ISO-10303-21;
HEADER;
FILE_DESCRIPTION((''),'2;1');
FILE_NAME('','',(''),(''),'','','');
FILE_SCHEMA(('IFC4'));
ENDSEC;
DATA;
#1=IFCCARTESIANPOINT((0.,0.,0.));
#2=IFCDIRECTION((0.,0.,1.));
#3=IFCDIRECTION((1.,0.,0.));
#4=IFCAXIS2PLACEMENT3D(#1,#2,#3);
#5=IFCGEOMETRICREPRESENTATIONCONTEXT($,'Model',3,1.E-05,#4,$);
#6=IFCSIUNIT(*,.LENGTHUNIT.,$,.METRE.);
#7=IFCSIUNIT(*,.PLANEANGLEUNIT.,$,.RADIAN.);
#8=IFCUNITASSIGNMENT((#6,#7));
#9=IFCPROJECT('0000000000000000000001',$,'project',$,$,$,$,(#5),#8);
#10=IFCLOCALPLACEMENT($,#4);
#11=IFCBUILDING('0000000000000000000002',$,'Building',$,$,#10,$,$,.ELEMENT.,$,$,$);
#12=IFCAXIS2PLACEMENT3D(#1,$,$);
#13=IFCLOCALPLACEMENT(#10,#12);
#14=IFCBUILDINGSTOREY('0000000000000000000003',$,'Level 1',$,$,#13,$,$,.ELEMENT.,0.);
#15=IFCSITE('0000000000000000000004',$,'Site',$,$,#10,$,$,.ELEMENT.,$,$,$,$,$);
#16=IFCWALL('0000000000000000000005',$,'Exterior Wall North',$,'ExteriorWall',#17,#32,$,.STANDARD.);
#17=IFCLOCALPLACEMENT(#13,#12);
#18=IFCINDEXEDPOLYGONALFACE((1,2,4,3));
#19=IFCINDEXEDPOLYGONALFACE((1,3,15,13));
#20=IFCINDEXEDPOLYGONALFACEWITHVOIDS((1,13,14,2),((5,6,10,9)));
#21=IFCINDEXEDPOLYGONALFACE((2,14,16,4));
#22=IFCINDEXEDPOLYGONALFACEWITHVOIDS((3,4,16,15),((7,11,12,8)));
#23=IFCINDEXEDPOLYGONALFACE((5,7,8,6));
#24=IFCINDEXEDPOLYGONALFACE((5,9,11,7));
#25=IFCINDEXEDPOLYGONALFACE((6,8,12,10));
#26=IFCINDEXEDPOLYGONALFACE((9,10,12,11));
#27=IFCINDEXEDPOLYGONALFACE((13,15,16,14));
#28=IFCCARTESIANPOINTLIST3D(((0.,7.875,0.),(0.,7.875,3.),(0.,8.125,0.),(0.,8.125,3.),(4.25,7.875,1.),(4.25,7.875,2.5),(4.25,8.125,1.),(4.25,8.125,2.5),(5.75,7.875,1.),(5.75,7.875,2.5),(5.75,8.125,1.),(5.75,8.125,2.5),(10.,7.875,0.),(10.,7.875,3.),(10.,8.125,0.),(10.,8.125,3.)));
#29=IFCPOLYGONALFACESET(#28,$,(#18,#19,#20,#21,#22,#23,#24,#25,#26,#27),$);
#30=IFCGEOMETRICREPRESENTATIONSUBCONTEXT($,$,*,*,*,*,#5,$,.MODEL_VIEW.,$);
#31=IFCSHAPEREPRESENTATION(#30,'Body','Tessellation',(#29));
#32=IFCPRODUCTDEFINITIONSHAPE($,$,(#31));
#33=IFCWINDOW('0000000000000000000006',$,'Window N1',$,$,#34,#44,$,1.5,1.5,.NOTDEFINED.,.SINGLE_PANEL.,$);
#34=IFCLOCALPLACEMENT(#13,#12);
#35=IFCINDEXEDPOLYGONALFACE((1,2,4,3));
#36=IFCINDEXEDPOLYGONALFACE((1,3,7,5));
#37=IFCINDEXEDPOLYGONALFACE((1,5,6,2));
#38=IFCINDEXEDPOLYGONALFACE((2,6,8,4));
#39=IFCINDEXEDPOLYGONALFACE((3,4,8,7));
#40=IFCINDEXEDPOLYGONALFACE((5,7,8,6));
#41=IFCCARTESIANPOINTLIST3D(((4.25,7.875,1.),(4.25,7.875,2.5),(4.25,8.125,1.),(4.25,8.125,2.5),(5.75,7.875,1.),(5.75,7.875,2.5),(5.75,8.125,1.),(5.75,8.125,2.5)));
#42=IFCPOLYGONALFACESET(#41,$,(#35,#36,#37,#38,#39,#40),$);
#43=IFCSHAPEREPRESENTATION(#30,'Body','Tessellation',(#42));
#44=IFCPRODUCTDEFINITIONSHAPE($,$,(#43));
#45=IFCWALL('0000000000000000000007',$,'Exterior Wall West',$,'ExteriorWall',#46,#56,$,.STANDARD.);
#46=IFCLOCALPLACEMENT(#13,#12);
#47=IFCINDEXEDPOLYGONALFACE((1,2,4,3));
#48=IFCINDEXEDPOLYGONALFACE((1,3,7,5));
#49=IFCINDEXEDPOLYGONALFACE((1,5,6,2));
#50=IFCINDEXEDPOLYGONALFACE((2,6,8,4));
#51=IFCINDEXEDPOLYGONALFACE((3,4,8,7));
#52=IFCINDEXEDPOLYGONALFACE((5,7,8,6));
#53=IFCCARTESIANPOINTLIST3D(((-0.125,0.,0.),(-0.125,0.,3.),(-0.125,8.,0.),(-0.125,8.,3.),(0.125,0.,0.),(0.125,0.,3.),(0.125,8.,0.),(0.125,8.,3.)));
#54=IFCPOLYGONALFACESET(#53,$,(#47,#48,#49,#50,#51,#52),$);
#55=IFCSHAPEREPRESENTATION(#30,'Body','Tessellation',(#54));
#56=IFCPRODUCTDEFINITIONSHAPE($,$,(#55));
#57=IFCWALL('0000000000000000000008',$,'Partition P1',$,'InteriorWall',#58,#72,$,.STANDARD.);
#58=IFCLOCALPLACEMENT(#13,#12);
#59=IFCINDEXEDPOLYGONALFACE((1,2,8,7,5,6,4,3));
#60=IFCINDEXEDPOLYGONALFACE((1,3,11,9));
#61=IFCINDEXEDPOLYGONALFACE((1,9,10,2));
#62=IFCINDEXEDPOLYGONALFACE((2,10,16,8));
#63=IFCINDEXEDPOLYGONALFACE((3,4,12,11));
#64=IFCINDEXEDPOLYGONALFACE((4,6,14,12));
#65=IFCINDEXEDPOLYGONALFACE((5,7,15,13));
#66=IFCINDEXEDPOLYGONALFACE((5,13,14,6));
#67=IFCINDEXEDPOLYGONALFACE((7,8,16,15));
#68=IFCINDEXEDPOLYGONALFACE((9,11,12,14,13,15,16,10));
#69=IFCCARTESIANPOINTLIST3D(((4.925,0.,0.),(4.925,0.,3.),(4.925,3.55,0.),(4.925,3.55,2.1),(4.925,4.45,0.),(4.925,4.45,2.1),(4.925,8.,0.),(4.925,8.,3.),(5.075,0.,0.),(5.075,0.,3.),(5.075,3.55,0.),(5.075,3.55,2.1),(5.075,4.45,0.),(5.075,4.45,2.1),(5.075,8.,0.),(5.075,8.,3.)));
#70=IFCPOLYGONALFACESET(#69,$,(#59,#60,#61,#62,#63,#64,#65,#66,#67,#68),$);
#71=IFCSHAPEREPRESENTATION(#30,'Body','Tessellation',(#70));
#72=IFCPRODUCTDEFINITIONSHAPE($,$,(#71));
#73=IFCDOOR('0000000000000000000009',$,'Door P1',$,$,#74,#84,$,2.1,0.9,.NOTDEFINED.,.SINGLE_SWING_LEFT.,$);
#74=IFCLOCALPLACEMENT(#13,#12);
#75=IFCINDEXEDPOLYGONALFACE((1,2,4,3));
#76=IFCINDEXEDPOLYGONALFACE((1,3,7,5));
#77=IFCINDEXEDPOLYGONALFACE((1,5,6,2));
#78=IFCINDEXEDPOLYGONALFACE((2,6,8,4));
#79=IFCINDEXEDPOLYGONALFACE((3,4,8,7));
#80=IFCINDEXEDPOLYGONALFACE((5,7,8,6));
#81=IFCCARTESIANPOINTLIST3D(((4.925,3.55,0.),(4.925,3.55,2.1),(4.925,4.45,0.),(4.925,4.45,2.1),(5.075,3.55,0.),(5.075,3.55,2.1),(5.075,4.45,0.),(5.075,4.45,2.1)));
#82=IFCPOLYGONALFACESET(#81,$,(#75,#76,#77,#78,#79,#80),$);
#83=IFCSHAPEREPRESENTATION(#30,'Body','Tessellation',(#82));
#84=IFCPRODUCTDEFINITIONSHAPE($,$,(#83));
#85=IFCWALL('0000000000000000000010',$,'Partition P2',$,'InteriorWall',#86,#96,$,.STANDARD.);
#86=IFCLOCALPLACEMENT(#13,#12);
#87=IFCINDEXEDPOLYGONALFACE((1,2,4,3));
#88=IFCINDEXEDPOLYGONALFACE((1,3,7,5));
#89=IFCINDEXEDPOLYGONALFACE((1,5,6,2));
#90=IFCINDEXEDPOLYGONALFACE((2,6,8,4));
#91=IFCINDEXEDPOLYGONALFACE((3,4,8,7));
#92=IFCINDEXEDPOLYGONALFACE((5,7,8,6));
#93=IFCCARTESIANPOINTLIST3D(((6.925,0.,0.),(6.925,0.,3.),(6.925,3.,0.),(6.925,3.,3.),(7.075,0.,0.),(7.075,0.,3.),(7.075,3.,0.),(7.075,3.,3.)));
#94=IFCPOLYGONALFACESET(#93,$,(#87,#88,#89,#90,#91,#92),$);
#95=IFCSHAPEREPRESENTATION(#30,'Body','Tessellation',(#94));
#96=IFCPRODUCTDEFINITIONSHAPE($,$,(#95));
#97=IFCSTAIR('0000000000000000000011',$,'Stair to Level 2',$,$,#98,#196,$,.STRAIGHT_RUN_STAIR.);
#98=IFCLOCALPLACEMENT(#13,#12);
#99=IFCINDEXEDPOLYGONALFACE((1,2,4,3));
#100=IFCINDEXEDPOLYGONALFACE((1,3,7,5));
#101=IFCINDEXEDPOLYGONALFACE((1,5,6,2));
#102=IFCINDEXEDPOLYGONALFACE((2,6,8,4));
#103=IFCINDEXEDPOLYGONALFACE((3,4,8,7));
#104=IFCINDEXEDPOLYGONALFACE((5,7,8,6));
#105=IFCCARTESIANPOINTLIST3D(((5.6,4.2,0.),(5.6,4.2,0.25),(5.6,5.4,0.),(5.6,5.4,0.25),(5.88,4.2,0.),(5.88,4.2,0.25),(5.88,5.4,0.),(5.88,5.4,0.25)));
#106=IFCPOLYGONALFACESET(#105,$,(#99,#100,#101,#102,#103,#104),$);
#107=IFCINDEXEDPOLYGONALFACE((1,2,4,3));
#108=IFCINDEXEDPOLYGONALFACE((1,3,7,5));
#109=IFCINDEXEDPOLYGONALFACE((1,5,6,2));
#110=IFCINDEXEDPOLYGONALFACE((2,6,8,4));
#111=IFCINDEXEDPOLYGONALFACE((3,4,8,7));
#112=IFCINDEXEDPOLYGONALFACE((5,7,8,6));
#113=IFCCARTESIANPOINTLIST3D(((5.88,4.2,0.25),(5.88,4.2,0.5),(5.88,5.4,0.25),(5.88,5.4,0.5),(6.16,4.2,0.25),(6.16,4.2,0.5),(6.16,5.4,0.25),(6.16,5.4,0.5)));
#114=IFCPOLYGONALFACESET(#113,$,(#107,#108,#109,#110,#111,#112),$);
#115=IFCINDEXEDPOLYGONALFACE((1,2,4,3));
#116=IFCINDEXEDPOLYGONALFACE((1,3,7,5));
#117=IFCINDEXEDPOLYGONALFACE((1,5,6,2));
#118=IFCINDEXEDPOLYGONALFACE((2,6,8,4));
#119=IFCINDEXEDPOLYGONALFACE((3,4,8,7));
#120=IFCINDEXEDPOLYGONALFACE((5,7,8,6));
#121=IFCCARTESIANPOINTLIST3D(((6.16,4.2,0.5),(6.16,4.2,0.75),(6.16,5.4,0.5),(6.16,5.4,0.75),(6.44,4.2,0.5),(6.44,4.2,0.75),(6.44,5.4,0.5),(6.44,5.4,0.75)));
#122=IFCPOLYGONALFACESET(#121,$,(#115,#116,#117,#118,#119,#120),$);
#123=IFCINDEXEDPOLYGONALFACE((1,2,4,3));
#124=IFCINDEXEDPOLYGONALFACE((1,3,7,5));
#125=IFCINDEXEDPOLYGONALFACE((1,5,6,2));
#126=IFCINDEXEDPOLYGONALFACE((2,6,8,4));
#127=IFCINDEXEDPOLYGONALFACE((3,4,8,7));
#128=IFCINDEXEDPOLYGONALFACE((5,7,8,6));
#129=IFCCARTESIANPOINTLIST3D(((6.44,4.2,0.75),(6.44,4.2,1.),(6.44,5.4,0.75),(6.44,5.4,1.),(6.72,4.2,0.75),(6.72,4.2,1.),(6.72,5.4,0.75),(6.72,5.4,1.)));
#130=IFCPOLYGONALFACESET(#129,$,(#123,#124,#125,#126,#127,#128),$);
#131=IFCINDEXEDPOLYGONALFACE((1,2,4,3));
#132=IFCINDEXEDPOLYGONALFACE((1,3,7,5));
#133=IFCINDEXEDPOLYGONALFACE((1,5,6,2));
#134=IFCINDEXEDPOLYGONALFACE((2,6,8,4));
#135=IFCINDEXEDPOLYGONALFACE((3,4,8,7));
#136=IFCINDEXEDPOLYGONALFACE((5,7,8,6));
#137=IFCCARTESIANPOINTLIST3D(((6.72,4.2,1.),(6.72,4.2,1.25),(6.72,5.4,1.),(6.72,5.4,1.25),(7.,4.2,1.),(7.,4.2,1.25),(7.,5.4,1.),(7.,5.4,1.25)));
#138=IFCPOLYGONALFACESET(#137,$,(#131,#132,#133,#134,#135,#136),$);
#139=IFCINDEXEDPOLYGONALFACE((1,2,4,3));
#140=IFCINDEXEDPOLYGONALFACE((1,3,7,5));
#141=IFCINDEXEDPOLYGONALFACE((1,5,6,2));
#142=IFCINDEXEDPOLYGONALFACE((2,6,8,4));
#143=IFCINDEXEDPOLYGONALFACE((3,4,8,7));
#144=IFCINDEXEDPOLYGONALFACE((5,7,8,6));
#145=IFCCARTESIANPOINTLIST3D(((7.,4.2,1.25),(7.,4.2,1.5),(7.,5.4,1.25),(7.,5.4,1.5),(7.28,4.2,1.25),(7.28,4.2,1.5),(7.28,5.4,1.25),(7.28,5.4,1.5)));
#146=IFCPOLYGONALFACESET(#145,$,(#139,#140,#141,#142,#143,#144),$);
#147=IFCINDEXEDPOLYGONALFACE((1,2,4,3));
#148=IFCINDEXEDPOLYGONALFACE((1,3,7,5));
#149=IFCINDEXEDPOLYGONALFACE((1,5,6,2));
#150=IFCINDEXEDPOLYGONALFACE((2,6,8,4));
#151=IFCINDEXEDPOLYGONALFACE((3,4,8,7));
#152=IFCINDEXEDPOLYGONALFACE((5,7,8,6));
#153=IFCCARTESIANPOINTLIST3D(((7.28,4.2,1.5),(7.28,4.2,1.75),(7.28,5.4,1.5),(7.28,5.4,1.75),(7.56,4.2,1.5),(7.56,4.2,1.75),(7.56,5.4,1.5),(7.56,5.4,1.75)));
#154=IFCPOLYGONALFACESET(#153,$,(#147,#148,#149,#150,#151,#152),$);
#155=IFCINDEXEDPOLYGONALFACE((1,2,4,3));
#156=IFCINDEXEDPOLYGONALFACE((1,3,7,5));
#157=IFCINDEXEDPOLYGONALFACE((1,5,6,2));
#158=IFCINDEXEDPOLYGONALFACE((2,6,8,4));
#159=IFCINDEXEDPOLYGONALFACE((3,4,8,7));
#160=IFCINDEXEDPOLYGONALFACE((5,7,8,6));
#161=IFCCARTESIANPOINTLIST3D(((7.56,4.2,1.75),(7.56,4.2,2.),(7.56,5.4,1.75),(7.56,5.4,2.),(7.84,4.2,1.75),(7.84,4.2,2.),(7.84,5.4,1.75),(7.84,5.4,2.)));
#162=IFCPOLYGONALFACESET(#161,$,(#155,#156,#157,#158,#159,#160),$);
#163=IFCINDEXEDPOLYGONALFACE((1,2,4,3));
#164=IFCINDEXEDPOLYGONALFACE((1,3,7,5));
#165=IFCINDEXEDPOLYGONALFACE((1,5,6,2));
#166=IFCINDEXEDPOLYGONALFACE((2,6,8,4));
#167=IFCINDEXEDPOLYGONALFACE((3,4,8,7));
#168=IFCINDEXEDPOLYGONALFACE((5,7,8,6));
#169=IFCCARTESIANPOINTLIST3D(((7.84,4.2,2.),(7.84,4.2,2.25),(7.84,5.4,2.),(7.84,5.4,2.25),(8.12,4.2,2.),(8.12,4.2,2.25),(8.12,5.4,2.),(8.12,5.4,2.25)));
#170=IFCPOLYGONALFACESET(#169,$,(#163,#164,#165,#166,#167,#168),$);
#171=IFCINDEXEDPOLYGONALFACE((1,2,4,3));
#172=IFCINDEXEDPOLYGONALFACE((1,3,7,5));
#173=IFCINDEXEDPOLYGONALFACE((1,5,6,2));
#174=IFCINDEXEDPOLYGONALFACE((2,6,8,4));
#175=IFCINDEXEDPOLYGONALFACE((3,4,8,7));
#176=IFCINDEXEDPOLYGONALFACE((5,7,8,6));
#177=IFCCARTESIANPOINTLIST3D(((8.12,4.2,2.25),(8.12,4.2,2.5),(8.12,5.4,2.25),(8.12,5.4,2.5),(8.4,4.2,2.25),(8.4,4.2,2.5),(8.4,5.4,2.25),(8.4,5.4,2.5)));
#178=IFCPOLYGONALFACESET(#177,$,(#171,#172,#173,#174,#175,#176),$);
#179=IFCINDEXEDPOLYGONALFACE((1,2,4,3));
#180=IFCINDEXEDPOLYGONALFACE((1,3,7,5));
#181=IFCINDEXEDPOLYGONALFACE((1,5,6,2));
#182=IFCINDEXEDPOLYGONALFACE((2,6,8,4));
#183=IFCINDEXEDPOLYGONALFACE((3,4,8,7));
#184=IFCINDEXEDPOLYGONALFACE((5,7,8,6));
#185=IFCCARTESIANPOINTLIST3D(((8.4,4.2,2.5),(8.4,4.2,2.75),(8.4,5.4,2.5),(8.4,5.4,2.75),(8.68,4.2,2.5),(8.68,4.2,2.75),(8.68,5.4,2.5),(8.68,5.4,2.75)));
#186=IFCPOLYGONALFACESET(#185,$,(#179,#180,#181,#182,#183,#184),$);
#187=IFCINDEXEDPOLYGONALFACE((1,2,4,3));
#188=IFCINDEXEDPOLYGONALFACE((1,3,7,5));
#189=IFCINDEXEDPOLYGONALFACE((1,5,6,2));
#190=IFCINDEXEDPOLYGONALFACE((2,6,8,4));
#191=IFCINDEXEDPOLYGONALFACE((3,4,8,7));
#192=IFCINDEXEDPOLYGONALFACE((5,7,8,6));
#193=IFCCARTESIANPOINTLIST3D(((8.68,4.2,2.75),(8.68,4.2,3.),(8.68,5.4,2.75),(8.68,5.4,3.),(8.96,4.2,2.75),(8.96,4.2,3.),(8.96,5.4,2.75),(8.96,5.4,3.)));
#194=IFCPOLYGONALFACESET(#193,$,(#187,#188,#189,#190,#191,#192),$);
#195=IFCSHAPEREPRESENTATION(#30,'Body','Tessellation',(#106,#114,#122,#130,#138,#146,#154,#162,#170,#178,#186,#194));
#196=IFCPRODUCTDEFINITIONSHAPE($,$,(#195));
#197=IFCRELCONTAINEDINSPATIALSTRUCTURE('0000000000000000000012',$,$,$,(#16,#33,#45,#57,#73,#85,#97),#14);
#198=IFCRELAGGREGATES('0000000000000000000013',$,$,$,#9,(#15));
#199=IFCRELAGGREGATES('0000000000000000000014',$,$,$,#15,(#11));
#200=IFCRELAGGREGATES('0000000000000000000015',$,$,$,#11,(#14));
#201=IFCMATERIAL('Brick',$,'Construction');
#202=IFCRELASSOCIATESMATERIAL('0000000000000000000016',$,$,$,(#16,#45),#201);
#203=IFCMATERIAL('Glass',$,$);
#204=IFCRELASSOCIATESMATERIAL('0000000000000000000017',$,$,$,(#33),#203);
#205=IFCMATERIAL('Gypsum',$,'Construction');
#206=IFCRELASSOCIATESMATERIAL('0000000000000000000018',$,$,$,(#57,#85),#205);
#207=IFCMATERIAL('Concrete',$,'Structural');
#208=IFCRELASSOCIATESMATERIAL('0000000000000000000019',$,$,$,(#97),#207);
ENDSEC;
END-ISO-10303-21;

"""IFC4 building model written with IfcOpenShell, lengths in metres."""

from ifc_helpers import new_model, si_unit, frame, frame_2d, origin, origin_with_axes, place, context, subcontext, project, spatial, rectangle, extrude, material, element, fill, save


model = new_model("IFC4")

# Units and contexts
model_context = context("Model", 3, precision=1e-05, world=origin_with_axes())
sub_context = subcontext(model_context, None, None, "MODEL_VIEW")
ifc_project = project(units=[si_unit("LENGTHUNIT", "METRE"), si_unit("PLANEANGLEUNIT", "RADIAN")], contexts=[model_context])

# Site, building, storey
placement = place(None, origin_with_axes())
site = spatial("IfcSite", under=ifc_project, at=placement, Name="Site", CompositionType="ELEMENT")
building = spatial("IfcBuilding", under=site, at=placement, Name="Building", CompositionType="ELEMENT")
storey_placement = place(placement, origin())
storey = spatial("IfcBuildingStorey", under=building, at=storey_placement, Name="Level 1", CompositionType="ELEMENT", Elevation=0.0)

# Shared definitions
ifc_material_1 = material(Name="Concrete", Category="Structural")

# Shared definitions
ifc_material_2 = material(Name="Brick", Category="Construction")

# Wall, opening, window
ifc_material_3 = material(Name="Glass")
wall_1_placement = place(storey_placement, frame((10.0, 8.0, 0.0), x_axis=(-1.0, 0.0, 0.0)))
wall_1 = element("IfcWall", 1, at=wall_1_placement, inside=storey, material=ifc_material_2, Name="Exterior Wall North", ObjectType="ExteriorWall", PredefinedType="STANDARD", context=sub_context, shape_type="SweptSolid", body=[
    extrude(rectangle(XDim=10.0, YDim=0.25, at=frame_2d((5.0, 0.0))), origin(), (0.0, 0.0, 1.0), 3.0),
])
opening_1_placement = place(wall_1_placement, frame((5.0, 0.175, 1.0), z_axis=(0.0, -1.0, 0.0), x_axis=(1.0, 0.0, 0.0)))
opening_1 = element("IfcOpeningElement", 2, at=opening_1_placement, cuts=wall_1, PredefinedType="OPENING", context=sub_context, shape_type="SweptSolid", body=[
    extrude(rectangle(XDim=1.5, YDim=1.5, at=frame_2d((0.0, 0.75))), origin(), (0.0, 0.0, 1.0), 0.35),
])
window_1_placement = place(wall_1_placement, frame((5.0, 0.125, 1.0), z_axis=(0.0, -1.0, 0.0), x_axis=(1.0, 0.0, 0.0)))
window_1 = element("IfcWindow", 3, at=window_1_placement, inside=storey, material=ifc_material_3, Name="Window N1", OverallHeight=1.5, OverallWidth=1.5, PartitioningType="SINGLE_PANEL", PredefinedType="NOTDEFINED", context=sub_context, shape_type="SweptSolid", body=[
    extrude(rectangle(XDim=1.5, YDim=1.5, at=frame_2d((0.0, 0.75))), origin(), (0.0, 0.0, 1.0), 0.25),
])
fill(opening_1, window_1)

# Wall
wall_2_placement = place(storey_placement, frame((0.0, 8.0, 0.0), x_axis=(0.0, -1.0, 0.0)))
element("IfcWall", 4, at=wall_2_placement, inside=storey, material=ifc_material_2, Name="Exterior Wall West", ObjectType="ExteriorWall", PredefinedType="STANDARD", context=sub_context, shape_type="SweptSolid", body=[
    extrude(rectangle(XDim=8.0, YDim=0.25, at=frame_2d((4.0, 0.0))), origin(), (0.0, 0.0, 1.0), 3.0),
])

# Wall, opening, door
ifc_material_4 = material(Name="Gypsum", Category="Construction")
wall_3_placement = place(storey_placement, frame((5.0, 0.0, 0.0), x_axis=(0.0, 1.0, 0.0)))
wall_3 = element("IfcWall", 5, at=wall_3_placement, inside=storey, material=ifc_material_4, Name="Partition P1", ObjectType="InteriorWall", PredefinedType="STANDARD", context=sub_context, shape_type="SweptSolid", body=[
    extrude(rectangle(XDim=8.0, YDim=0.15, at=frame_2d((4.0, 0.0))), origin(), (0.0, 0.0, 1.0), 3.0),
])
opening_2_placement = place(wall_3_placement, frame((4.0, 0.125, 0.0), z_axis=(0.0, -1.0, 0.0), x_axis=(1.0, 0.0, 0.0)))
opening_2 = element("IfcOpeningElement", 6, at=opening_2_placement, cuts=wall_3, PredefinedType="OPENING", context=sub_context, shape_type="SweptSolid", body=[
    extrude(rectangle(XDim=0.9, YDim=2.1, at=frame_2d((0.0, 1.05))), origin(), (0.0, 0.0, 1.0), 0.25),
])
door_1_placement = place(wall_3_placement, frame((4.0, 0.075, 0.0), z_axis=(0.0, -1.0, 0.0), x_axis=(1.0, 0.0, 0.0)))
door_1 = element("IfcDoor", 7, at=door_1_placement, inside=storey, Name="Door P1", OperationType="SINGLE_SWING_LEFT", OverallHeight=2.1, OverallWidth=0.9, PredefinedType="NOTDEFINED", context=sub_context, shape_type="SweptSolid", body=[
    extrude(rectangle(XDim=0.9, YDim=2.1, at=frame_2d((0.0, 1.05))), origin(), (0.0, 0.0, 1.0), 0.15),
])
fill(opening_2, door_1)

# Wall
wall_4_placement = place(storey_placement, frame((7.0, 0.0, 0.0), x_axis=(0.0, 1.0, 0.0)))
element("IfcWall", 8, at=wall_4_placement, inside=storey, material=ifc_material_4, Name="Partition P2", ObjectType="InteriorWall", PredefinedType="STANDARD", context=sub_context, shape_type="SweptSolid", body=[
    extrude(rectangle(XDim=3.0, YDim=0.15, at=frame_2d((1.5, 0.0))), origin(), (0.0, 0.0, 1.0), 3.0),
])

# Stair
stair_placement = place(storey_placement, frame((5.6, 4.2, 0.0)))
element("IfcStair", 9, at=stair_placement, inside=storey, material=ifc_material_1, Name="Stair to Level 2", PredefinedType="STRAIGHT_RUN_STAIR", context=sub_context, shape_type="SolidModel", body=[
    extrude(rectangle(XDim=0.28, YDim=1.2, at=frame_2d((0.14, 0.6))), origin(), (0.0, 0.0, 1.0), 0.25),
    extrude(rectangle(XDim=0.28, YDim=1.2, at=frame_2d((0.14, 0.6))), frame((0.28, 0.0, 0.25)), (0.0, 0.0, 1.0), 0.25),
    extrude(rectangle(XDim=0.28, YDim=1.2, at=frame_2d((0.14, 0.6))), frame((0.56, 0.0, 0.5)), (0.0, 0.0, 1.0), 0.25),
    extrude(rectangle(XDim=0.28, YDim=1.2, at=frame_2d((0.14, 0.6))), frame((0.84, 0.0, 0.75)), (0.0, 0.0, 1.0), 0.25),
    extrude(rectangle(XDim=0.28, YDim=1.2, at=frame_2d((0.14, 0.6))), frame((1.12, 0.0, 1.0)), (0.0, 0.0, 1.0), 0.25),
    extrude(rectangle(XDim=0.28, YDim=1.2, at=frame_2d((0.14, 0.6))), frame((1.4, 0.0, 1.25)), (0.0, 0.0, 1.0), 0.25),
    extrude(rectangle(XDim=0.28, YDim=1.2, at=frame_2d((0.14, 0.6))), frame((1.68, 0.0, 1.5)), (0.0, 0.0, 1.0), 0.25),
    extrude(rectangle(XDim=0.28, YDim=1.2, at=frame_2d((0.14, 0.6))), frame((1.96, 0.0, 1.75)), (0.0, 0.0, 1.0), 0.25),
    extrude(rectangle(XDim=0.28, YDim=1.2, at=frame_2d((0.14, 0.6))), frame((2.24, 0.0, 2.0)), (0.0, 0.0, 1.0), 0.25),
    extrude(rectangle(XDim=0.28, YDim=1.2, at=frame_2d((0.14, 0.6))), frame((2.52, 0.0, 2.25)), (0.0, 0.0, 1.0), 0.25),
    extrude(rectangle(XDim=0.28, YDim=1.2, at=frame_2d((0.14, 0.6))), frame((2.8, 0.0, 2.5)), (0.0, 0.0, 1.0), 0.25),
    extrude(rectangle(XDim=0.28, YDim=1.2, at=frame_2d((0.14, 0.6))), frame((3.08, 0.0, 2.75)), (0.0, 0.0, 1.0), 0.25),
])

save(model, "model.ifc")
